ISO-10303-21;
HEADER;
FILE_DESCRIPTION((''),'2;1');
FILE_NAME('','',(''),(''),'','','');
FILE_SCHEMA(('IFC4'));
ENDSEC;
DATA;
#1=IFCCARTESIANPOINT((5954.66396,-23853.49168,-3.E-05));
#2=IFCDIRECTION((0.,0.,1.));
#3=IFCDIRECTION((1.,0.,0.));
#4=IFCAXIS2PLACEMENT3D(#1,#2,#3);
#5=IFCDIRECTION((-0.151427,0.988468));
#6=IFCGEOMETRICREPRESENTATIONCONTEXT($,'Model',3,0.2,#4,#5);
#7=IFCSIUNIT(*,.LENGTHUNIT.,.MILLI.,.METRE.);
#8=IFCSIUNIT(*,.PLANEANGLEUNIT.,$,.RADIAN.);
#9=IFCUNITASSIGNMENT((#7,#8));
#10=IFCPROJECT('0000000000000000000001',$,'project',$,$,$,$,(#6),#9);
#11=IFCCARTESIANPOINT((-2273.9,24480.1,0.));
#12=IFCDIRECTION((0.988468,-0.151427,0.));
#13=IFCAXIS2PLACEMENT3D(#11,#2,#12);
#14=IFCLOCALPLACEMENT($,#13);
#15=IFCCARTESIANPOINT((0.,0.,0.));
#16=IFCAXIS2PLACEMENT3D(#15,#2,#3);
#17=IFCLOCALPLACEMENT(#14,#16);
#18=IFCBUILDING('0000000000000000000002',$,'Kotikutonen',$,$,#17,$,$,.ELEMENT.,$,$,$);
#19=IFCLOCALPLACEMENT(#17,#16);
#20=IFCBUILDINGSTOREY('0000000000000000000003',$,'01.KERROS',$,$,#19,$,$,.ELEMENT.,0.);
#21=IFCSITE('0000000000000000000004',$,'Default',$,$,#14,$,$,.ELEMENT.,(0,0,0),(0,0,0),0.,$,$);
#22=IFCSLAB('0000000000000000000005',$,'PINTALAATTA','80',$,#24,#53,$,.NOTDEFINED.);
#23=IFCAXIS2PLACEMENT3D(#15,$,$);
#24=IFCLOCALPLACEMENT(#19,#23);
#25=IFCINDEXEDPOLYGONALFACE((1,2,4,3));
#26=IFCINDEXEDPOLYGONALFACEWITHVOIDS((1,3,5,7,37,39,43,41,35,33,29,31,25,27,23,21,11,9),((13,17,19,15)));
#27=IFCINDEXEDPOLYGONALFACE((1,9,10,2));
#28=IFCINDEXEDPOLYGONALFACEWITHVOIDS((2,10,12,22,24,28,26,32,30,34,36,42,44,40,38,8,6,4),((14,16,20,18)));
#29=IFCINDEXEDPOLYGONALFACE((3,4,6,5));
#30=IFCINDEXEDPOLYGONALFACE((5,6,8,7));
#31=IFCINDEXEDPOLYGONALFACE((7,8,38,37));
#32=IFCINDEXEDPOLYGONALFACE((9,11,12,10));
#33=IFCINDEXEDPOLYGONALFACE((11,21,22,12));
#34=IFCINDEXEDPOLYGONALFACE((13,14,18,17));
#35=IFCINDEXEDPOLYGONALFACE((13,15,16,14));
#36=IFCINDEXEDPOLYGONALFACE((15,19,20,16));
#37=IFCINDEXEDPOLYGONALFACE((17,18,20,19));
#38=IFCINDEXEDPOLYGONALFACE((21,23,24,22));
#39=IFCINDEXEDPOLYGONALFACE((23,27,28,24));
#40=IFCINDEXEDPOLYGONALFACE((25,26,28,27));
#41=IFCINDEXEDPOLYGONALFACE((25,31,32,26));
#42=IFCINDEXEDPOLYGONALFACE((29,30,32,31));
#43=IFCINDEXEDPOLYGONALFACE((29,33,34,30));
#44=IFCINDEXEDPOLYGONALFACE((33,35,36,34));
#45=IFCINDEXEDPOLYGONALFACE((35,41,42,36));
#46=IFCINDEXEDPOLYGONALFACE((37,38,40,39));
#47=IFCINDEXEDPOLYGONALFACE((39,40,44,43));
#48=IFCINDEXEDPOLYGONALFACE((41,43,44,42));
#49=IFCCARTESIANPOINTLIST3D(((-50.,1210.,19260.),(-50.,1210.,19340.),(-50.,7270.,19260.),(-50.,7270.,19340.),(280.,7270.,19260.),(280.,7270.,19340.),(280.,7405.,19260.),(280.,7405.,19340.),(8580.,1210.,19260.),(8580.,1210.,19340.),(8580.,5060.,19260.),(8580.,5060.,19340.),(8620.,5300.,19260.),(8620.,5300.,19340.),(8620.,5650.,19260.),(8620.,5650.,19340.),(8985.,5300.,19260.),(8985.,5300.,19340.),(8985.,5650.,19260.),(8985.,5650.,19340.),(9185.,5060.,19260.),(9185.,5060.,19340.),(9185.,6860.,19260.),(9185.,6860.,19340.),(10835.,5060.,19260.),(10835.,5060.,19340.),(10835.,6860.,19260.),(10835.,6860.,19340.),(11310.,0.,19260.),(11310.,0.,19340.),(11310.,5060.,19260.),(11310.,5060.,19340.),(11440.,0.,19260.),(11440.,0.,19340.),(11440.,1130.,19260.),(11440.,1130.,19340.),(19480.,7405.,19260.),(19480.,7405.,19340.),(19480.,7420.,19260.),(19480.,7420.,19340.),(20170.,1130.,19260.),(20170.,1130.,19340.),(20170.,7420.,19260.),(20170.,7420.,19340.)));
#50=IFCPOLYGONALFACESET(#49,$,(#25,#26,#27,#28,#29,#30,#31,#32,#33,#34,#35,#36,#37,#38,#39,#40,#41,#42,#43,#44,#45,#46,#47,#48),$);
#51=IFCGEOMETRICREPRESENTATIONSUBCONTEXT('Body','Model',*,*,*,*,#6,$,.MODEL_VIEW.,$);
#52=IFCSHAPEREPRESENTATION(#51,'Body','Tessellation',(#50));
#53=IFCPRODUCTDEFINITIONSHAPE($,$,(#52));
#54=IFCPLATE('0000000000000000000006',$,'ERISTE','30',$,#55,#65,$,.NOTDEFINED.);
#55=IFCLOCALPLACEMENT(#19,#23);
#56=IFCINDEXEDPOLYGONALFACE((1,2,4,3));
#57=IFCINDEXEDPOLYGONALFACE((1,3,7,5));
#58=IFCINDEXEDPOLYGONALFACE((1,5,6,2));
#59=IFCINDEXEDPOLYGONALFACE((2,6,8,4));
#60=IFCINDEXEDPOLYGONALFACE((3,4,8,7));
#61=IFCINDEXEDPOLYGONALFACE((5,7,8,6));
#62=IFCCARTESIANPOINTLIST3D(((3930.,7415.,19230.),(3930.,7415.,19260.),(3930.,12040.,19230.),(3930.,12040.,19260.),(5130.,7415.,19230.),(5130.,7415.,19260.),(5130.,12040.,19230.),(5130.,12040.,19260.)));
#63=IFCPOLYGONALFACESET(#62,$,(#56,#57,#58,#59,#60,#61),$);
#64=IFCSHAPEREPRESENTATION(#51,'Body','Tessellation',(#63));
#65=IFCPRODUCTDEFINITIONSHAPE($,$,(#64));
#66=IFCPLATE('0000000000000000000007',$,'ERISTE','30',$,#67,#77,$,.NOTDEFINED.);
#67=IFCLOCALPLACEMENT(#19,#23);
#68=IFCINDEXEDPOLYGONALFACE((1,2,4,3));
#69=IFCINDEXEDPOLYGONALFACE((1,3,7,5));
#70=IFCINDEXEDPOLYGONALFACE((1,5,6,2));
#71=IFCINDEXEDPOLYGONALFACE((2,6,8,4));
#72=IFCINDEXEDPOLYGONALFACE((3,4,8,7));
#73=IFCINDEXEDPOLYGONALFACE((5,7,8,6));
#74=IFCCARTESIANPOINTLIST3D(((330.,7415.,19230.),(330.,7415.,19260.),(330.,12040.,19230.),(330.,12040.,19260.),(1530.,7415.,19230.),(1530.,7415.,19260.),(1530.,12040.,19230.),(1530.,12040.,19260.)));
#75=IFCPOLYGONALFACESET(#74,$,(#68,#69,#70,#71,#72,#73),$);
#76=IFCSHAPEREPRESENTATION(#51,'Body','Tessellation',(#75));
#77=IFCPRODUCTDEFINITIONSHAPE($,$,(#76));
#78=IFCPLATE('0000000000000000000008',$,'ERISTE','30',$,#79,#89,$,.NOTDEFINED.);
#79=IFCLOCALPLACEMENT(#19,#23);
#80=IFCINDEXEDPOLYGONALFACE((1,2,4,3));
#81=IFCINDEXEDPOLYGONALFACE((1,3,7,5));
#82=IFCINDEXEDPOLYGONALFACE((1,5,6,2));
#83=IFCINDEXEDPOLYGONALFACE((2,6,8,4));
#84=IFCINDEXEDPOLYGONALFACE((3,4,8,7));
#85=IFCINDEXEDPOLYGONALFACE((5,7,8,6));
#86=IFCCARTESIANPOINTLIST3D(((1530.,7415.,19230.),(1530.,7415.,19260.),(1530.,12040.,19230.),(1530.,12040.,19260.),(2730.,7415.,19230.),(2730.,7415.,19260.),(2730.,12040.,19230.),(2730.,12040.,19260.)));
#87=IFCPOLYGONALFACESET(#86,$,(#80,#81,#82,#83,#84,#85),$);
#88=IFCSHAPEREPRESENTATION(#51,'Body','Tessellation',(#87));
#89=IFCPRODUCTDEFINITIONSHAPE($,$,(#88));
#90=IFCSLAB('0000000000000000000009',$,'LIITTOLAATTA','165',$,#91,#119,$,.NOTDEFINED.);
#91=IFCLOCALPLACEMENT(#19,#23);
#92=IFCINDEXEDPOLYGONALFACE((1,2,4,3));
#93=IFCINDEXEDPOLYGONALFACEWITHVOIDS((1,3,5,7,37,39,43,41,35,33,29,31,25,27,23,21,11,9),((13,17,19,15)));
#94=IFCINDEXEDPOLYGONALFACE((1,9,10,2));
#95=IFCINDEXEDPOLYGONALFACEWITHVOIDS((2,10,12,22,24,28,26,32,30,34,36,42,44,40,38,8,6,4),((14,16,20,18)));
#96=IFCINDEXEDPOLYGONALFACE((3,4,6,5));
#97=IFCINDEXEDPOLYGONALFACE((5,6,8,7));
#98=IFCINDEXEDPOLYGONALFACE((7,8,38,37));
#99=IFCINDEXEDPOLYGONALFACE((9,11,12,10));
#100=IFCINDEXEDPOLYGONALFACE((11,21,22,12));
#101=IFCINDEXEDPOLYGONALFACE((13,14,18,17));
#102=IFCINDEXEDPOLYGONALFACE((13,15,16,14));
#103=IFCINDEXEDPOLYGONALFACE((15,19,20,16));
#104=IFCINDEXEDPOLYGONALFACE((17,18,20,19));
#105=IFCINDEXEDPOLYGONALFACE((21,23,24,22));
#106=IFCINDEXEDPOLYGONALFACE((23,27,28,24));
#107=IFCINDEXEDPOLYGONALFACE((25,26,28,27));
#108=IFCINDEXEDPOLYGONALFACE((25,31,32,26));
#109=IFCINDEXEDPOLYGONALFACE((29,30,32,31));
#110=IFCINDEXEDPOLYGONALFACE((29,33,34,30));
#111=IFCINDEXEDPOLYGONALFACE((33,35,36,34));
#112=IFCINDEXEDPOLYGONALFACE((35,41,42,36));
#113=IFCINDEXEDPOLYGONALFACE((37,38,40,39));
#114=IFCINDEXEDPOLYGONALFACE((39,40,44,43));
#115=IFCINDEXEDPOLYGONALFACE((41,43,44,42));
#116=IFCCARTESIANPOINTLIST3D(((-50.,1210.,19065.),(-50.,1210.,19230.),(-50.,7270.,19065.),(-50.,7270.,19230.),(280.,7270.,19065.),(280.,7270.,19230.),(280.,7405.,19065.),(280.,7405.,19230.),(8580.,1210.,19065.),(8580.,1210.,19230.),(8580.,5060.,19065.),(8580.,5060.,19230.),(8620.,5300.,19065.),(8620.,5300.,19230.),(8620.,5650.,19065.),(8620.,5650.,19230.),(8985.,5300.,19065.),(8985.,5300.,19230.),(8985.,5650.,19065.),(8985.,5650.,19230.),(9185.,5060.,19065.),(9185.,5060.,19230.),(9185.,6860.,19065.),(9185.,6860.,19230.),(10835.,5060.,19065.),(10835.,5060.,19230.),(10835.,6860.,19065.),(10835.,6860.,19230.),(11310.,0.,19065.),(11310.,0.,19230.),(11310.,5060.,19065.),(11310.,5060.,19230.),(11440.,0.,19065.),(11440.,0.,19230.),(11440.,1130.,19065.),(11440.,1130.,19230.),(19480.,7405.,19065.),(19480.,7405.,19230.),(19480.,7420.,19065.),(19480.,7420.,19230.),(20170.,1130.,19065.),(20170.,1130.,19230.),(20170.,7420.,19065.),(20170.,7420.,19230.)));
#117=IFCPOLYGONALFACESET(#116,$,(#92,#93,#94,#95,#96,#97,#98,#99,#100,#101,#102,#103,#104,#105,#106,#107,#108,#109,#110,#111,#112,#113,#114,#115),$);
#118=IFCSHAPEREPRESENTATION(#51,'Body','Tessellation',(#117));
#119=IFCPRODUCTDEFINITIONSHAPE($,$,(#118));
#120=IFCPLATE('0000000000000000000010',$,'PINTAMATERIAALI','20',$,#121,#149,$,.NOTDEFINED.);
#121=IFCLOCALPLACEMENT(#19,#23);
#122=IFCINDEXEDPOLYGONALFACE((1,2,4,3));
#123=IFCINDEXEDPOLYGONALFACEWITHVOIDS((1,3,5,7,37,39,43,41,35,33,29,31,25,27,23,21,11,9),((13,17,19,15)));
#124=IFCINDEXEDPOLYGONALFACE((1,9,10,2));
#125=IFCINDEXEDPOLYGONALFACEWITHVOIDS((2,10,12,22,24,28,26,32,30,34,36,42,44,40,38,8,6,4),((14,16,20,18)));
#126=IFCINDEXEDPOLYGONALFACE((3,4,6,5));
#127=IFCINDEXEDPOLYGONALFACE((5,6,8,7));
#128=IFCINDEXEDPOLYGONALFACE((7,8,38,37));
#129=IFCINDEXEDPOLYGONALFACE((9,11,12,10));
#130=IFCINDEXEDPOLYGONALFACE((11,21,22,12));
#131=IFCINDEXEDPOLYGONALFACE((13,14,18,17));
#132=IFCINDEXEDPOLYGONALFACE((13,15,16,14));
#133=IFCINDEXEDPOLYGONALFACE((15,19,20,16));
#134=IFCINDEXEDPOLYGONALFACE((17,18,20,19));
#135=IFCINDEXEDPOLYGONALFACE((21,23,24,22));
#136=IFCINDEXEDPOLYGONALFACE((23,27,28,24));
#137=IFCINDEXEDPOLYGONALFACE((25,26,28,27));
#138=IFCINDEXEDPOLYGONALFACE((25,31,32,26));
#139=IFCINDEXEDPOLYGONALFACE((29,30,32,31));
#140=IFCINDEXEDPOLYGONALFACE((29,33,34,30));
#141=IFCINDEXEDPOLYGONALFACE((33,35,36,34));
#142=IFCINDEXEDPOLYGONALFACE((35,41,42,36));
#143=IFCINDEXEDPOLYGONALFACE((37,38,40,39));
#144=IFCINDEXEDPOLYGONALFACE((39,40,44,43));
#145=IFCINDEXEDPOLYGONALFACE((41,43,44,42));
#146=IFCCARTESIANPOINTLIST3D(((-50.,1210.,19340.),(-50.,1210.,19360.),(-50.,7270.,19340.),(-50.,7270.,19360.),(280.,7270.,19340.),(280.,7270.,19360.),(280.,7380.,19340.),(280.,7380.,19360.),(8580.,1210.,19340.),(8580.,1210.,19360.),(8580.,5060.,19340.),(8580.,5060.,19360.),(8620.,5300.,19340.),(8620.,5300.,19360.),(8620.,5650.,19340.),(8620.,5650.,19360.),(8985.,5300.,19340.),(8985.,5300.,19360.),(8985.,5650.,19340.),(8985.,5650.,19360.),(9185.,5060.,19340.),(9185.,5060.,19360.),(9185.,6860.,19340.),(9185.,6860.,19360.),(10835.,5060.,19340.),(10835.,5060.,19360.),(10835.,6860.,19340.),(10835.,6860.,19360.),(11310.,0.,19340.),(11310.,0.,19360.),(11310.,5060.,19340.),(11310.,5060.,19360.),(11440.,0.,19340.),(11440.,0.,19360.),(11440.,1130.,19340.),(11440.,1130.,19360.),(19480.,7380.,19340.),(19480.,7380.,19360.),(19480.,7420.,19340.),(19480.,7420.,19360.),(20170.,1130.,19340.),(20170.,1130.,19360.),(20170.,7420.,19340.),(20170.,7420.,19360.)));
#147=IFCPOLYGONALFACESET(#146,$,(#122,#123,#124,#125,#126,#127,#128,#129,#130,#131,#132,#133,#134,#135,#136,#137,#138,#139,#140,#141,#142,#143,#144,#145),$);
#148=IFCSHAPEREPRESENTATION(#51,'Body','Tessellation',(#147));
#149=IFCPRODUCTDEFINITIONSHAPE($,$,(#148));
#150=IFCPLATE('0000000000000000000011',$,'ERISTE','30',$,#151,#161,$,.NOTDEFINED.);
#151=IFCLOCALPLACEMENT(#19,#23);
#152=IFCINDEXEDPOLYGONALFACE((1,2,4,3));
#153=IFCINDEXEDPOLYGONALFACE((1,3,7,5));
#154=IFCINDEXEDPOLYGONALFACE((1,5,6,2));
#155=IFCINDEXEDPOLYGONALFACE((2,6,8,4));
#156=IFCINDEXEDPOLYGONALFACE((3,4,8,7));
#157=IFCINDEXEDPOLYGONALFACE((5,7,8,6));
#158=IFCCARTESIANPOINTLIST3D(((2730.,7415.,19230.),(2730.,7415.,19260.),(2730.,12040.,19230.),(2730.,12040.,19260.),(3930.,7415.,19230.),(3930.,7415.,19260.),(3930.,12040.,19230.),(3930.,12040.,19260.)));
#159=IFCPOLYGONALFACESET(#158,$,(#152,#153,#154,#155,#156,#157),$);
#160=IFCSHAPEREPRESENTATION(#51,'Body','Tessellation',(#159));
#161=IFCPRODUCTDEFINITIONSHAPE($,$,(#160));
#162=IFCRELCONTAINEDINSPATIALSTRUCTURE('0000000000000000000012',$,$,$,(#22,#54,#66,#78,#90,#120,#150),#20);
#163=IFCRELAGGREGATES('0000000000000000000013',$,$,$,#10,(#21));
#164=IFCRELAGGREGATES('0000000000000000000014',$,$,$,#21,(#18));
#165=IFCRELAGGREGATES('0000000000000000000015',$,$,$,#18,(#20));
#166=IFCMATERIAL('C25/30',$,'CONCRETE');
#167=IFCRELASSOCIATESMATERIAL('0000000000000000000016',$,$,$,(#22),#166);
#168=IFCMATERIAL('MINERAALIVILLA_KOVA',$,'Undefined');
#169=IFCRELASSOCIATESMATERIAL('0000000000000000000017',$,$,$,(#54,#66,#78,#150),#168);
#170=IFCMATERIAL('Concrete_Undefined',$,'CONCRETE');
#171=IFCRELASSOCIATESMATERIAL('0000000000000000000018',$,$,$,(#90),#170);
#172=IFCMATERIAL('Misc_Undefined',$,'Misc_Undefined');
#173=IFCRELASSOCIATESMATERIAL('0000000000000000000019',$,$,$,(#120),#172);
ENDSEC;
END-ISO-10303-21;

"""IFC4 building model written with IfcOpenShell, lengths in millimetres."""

from ifc_helpers import new_model, si_unit, direction, frame, origin_with_axes, place, context, subcontext, project, spatial, line, indexed_curve, outline, extrude, material, element, save


model = new_model("IFC4")

# Units and contexts
model_context = context("Model", 3, precision=0.2, world=frame((5954.66396, -23853.49168, -3e-05), z_axis=(0.0, 0.0, 1.0), x_axis=(1.0, 0.0, 0.0)), true_north=direction((-0.151427, 0.988468)))
body_context = subcontext(model_context, "Body", "Model", "MODEL_VIEW")
ifc_project = project(units=[si_unit("LENGTHUNIT", "METRE", prefix="MILLI"), si_unit("PLANEANGLEUNIT", "RADIAN")], contexts=[model_context])

# Site, building, storey
site_placement = place(None, frame((-2273.9, 24480.1, 0.0), z_axis=(0.0, 0.0, 1.0), x_axis=(0.988468, -0.151427, 0.0)))
site = spatial("IfcSite", under=ifc_project, at=site_placement, Name="Default", CompositionType="ELEMENT", RefLatitude=(0, 0, 0), RefLongitude=(0, 0, 0), RefElevation=0.0)
building_placement = place(site_placement, origin_with_axes())
building = spatial("IfcBuilding", under=site, at=building_placement, Name="Kotikutonen", CompositionType="ELEMENT")
storey_placement = place(building_placement, origin_with_axes())
storey = spatial("IfcBuildingStorey", under=building, at=storey_placement, Name="01.KERROS", CompositionType="ELEMENT", Elevation=0.0)

# Shared definitions
ifc_material_1 = material(Name="Concrete_Undefined", Category="CONCRETE")

# Slab, voiding features
ifc_material_2 = material(Name="C25/30", Category="CONCRETE")
slab_1_placement = place(storey_placement, frame((280.0, 7270.0, 19300.0), z_axis=(0.0, 0.0, 1.0), x_axis=(-1.0, 0.0, 0.0)))
slab_1 = element("IfcSlab", 1, at=slab_1_placement, inside=storey, material=ifc_material_2, Name="PINTALAATTA", Description="80", PredefinedType="NOTDEFINED", context=body_context, shape_type="SolidModel", body=[
    extrude(outline(indexed_curve([(0.0, 0.0), (330.0, 0.0), (330.0, 6060.0), (-8300.0, 6060.0), (-8300.0, 7270.0), (-11160.0, 7270.0), (-11160.0, 6140.0), (-19890.0, 6140.0), (-19890.0, -150.0), (-19200.0, -150.0), (-19200.0, -135.0), (0.0, -135.0)], segments=[line(1, 2, 3, 4, 5, 6, 7, 8, 9, 10, 11, 12, 1)])), frame((0.0, 0.0, 40.0), z_axis=(0.0, 0.0, 1.0), x_axis=(1.0, 0.0, 0.0)), (0.0, 0.0, -1.0), 80.0),
])
voiding_feature_1_placement = place(slab_1_placement, frame((-8300.0, 2210.0, 0.0), z_axis=(0.0, 0.0, 1.0), x_axis=(0.0, 1.0, 0.0)))
element("IfcVoidingFeature", 2, at=voiding_feature_1_placement, cuts=slab_1, Name="POLYGON CUT", PredefinedType="HOLE", context=body_context, shape_type="SolidModel", body=[
    extrude(outline(indexed_curve([(0.0, 0.0), (5060.0, 0.0), (5060.0, 2730.0), (0.0, 2730.0), (0.0, 2255.0), (-1800.0, 2255.0), (-1800.0, 605.0), (0.0, 605.0)], segments=[line(1, 2, 3, 4, 5, 6, 7, 8, 1)])), frame((0.0, 0.0, 115.0), z_axis=(0.0, 0.0, 1.0), x_axis=(1.0, 0.0, 0.0)), (0.0, 0.0, -1.0), 230.0),
])
voiding_feature_2_placement = place(slab_1_placement, frame((-8705.0, 1970.0, 0.0), z_axis=(0.0, 0.0, 1.0), x_axis=(0.0, -1.0, 0.0)))
element("IfcVoidingFeature", 3, at=voiding_feature_2_placement, cuts=slab_1, Name="POLYGON CUT", PredefinedType="HOLE", context=body_context, shape_type="SolidModel", body=[
    extrude(outline(indexed_curve([(0.0, 0.0), (350.0, 0.0), (350.0, 365.0), (0.0, 365.0)], segments=[line(1, 2, 3, 4, 1)])), frame((0.0, 0.0, 115.0), z_axis=(0.0, 0.0, 1.0), x_axis=(1.0, 0.0, 0.0)), (0.0, 0.0, -1.0), 230.0),
])

# Plates
ifc_material_3 = material(Name="MINERAALIVILLA_KOVA", Category="Undefined")
for number, where, z_axis, x_axis, name in (
    (4, (3930.0, 7415.0, 19245.0), (0.0, 0.0, 1.0), (1.0, 0.0, 0.0), "ERISTE"),
    (5, (330.0, 7415.0, 19245.0), (0.0, 0.0, 1.0), (1.0, 0.0, 0.0), "ERISTE"),
    (6, (1530.0, 7415.0, 19245.0), (0.0, 0.0, 1.0), (1.0, 0.0, 0.0), "ERISTE"),
):
    element("IfcPlate", number, at=place(storey_placement, frame(where, z_axis=z_axis, x_axis=x_axis)), inside=storey, material=ifc_material_3, Name=name, Description="30", PredefinedType="NOTDEFINED", context=body_context, shape_type="SolidModel", body=[
        extrude(outline(indexed_curve([(0.0, 0.0), (1200.0, 0.0), (1200.0, 4625.0), (0.0, 4625.0)], segments=[line(1, 2, 3, 4, 1)])), frame((0.0, 0.0, 15.0), z_axis=(0.0, 0.0, 1.0), x_axis=(1.0, 0.0, 0.0)), (0.0, 0.0, -1.0), 30.0),
    ])

# Slab, voiding features
slab_2_placement = place(storey_placement, frame((280.0, 7270.0, 19147.5), z_axis=(0.0, 0.0, 1.0), x_axis=(-1.0, 0.0, 0.0)))
slab_2 = element("IfcSlab", 7, at=slab_2_placement, inside=storey, material=ifc_material_1, Name="LIITTOLAATTA", Description="165", PredefinedType="NOTDEFINED", context=body_context, shape_type="SolidModel", body=[
    extrude(outline(indexed_curve([(0.0, 0.0), (330.0, 0.0), (330.0, 6060.0), (-8300.0, 6060.0), (-8300.0, 7270.0), (-11160.0, 7270.0), (-11160.0, 6140.0), (-19890.0, 6140.0), (-19890.0, -150.0), (-19200.0, -150.0), (-19200.0, -135.0), (0.0, -135.0)], segments=[line(1, 2, 3, 4, 5, 6, 7, 8, 9, 10, 11, 12, 1)])), frame((0.0, 0.0, 82.5), z_axis=(0.0, 0.0, 1.0), x_axis=(1.0, 0.0, 0.0)), (0.0, 0.0, -1.0), 165.0),
])
voiding_feature_3_placement = place(slab_2_placement, frame((-8300.0, 2210.0, 0.0), z_axis=(0.0, 0.0, 1.0), x_axis=(0.0, 1.0, 0.0)))
element("IfcVoidingFeature", 8, at=voiding_feature_3_placement, cuts=slab_2, Name="POLYGON CUT", PredefinedType="HOLE", context=body_context, shape_type="SolidModel", body=[
    extrude(outline(indexed_curve([(0.0, 0.0), (5060.0, 0.0), (5060.0, 2730.0), (0.0, 2730.0), (0.0, 2255.0), (-1800.0, 2255.0), (-1800.0, 605.0), (0.0, 605.0)], segments=[line(1, 2, 3, 4, 5, 6, 7, 8, 1)])), frame((0.0, 0.0, 157.5), z_axis=(0.0, 0.0, 1.0), x_axis=(1.0, 0.0, 0.0)), (0.0, 0.0, -1.0), 315.0),
])
voiding_feature_4_placement = place(slab_2_placement, frame((-8705.0, 1970.0, 0.0), z_axis=(0.0, 0.0, 1.0), x_axis=(0.0, -1.0, 0.0)))
element("IfcVoidingFeature", 9, at=voiding_feature_4_placement, cuts=slab_2, Name="POLYGON CUT", PredefinedType="HOLE", context=body_context, shape_type="SolidModel", body=[
    extrude(outline(indexed_curve([(0.0, 0.0), (350.0, 0.0), (350.0, 365.0), (0.0, 365.0)], segments=[line(1, 2, 3, 4, 1)])), frame((0.0, 0.0, 157.5), z_axis=(0.0, 0.0, 1.0), x_axis=(1.0, 0.0, 0.0)), (0.0, 0.0, -1.0), 315.0),
])

# Plate, voiding features
ifc_material_4 = material(Name="Misc_Undefined", Category="Misc_Undefined")
plate_1_placement = place(storey_placement, frame((280.0, 7270.0, 19350.0), z_axis=(0.0, 0.0, 1.0), x_axis=(-1.0, 0.0, 0.0)))
plate_1 = element("IfcPlate", 10, at=plate_1_placement, inside=storey, material=ifc_material_4, Name="PINTAMATERIAALI", Description="20", PredefinedType="NOTDEFINED", context=body_context, shape_type="SolidModel", body=[
    extrude(outline(indexed_curve([(0.0, 0.0), (330.0, 0.0), (330.0, 6060.0), (-8300.0, 6060.0), (-8300.0, 7270.0), (-11160.0, 7270.0), (-11160.0, 6140.0), (-19890.0, 6140.0), (-19890.0, -150.0), (-19200.0, -150.0), (-19200.0, -110.0), (0.0, -110.0)], segments=[line(1, 2, 3, 4, 5, 6, 7, 8, 9, 10, 11, 12, 1)])), frame((0.0, 0.0, 10.0), z_axis=(0.0, 0.0, 1.0), x_axis=(1.0, 0.0, 0.0)), (0.0, 0.0, -1.0), 20.0),
])
voiding_feature_5_placement = place(plate_1_placement, frame((-8300.0, 2210.0, 0.0), z_axis=(0.0, 0.0, 1.0), x_axis=(0.0, 1.0, 0.0)))
element("IfcVoidingFeature", 11, at=voiding_feature_5_placement, cuts=plate_1, Name="POLYGON CUT", PredefinedType="HOLE", context=body_context, shape_type="SolidModel", body=[
    extrude(outline(indexed_curve([(0.0, 0.0), (5060.0, 0.0), (5060.0, 2730.0), (0.0, 2730.0), (0.0, 2255.0), (-1800.0, 2255.0), (-1800.0, 605.0), (0.0, 605.0)], segments=[line(1, 2, 3, 4, 5, 6, 7, 8, 1)])), frame((0.0, 0.0, 85.0), z_axis=(0.0, 0.0, 1.0), x_axis=(1.0, 0.0, 0.0)), (0.0, 0.0, -1.0), 170.0),
])
voiding_feature_6_placement = place(plate_1_placement, frame((-8705.0, 1970.0, 0.0), z_axis=(0.0, 0.0, 1.0), x_axis=(0.0, -1.0, 0.0)))
element("IfcVoidingFeature", 12, at=voiding_feature_6_placement, cuts=plate_1, Name="POLYGON CUT", PredefinedType="HOLE", context=body_context, shape_type="SolidModel", body=[
    extrude(outline(indexed_curve([(0.0, 0.0), (350.0, 0.0), (350.0, 365.0), (0.0, 365.0)], segments=[line(1, 2, 3, 4, 1)])), frame((0.0, 0.0, 85.0), z_axis=(0.0, 0.0, 1.0), x_axis=(1.0, 0.0, 0.0)), (0.0, 0.0, -1.0), 170.0),
])

# Plate
plate_2_placement = place(storey_placement, frame((2730.0, 7415.0, 19245.0), z_axis=(0.0, 0.0, 1.0), x_axis=(1.0, 0.0, 0.0)))
element("IfcPlate", 13, at=plate_2_placement, inside=storey, material=ifc_material_3, Name="ERISTE", Description="30", PredefinedType="NOTDEFINED", context=body_context, shape_type="SolidModel", body=[
    extrude(outline(indexed_curve([(0.0, 0.0), (1200.0, 0.0), (1200.0, 4625.0), (0.0, 4625.0)], segments=[line(1, 2, 3, 4, 1)])), frame((0.0, 0.0, 15.0), z_axis=(0.0, 0.0, 1.0), x_axis=(1.0, 0.0, 0.0)), (0.0, 0.0, -1.0), 30.0),
])

save(model, "model.ifc")
